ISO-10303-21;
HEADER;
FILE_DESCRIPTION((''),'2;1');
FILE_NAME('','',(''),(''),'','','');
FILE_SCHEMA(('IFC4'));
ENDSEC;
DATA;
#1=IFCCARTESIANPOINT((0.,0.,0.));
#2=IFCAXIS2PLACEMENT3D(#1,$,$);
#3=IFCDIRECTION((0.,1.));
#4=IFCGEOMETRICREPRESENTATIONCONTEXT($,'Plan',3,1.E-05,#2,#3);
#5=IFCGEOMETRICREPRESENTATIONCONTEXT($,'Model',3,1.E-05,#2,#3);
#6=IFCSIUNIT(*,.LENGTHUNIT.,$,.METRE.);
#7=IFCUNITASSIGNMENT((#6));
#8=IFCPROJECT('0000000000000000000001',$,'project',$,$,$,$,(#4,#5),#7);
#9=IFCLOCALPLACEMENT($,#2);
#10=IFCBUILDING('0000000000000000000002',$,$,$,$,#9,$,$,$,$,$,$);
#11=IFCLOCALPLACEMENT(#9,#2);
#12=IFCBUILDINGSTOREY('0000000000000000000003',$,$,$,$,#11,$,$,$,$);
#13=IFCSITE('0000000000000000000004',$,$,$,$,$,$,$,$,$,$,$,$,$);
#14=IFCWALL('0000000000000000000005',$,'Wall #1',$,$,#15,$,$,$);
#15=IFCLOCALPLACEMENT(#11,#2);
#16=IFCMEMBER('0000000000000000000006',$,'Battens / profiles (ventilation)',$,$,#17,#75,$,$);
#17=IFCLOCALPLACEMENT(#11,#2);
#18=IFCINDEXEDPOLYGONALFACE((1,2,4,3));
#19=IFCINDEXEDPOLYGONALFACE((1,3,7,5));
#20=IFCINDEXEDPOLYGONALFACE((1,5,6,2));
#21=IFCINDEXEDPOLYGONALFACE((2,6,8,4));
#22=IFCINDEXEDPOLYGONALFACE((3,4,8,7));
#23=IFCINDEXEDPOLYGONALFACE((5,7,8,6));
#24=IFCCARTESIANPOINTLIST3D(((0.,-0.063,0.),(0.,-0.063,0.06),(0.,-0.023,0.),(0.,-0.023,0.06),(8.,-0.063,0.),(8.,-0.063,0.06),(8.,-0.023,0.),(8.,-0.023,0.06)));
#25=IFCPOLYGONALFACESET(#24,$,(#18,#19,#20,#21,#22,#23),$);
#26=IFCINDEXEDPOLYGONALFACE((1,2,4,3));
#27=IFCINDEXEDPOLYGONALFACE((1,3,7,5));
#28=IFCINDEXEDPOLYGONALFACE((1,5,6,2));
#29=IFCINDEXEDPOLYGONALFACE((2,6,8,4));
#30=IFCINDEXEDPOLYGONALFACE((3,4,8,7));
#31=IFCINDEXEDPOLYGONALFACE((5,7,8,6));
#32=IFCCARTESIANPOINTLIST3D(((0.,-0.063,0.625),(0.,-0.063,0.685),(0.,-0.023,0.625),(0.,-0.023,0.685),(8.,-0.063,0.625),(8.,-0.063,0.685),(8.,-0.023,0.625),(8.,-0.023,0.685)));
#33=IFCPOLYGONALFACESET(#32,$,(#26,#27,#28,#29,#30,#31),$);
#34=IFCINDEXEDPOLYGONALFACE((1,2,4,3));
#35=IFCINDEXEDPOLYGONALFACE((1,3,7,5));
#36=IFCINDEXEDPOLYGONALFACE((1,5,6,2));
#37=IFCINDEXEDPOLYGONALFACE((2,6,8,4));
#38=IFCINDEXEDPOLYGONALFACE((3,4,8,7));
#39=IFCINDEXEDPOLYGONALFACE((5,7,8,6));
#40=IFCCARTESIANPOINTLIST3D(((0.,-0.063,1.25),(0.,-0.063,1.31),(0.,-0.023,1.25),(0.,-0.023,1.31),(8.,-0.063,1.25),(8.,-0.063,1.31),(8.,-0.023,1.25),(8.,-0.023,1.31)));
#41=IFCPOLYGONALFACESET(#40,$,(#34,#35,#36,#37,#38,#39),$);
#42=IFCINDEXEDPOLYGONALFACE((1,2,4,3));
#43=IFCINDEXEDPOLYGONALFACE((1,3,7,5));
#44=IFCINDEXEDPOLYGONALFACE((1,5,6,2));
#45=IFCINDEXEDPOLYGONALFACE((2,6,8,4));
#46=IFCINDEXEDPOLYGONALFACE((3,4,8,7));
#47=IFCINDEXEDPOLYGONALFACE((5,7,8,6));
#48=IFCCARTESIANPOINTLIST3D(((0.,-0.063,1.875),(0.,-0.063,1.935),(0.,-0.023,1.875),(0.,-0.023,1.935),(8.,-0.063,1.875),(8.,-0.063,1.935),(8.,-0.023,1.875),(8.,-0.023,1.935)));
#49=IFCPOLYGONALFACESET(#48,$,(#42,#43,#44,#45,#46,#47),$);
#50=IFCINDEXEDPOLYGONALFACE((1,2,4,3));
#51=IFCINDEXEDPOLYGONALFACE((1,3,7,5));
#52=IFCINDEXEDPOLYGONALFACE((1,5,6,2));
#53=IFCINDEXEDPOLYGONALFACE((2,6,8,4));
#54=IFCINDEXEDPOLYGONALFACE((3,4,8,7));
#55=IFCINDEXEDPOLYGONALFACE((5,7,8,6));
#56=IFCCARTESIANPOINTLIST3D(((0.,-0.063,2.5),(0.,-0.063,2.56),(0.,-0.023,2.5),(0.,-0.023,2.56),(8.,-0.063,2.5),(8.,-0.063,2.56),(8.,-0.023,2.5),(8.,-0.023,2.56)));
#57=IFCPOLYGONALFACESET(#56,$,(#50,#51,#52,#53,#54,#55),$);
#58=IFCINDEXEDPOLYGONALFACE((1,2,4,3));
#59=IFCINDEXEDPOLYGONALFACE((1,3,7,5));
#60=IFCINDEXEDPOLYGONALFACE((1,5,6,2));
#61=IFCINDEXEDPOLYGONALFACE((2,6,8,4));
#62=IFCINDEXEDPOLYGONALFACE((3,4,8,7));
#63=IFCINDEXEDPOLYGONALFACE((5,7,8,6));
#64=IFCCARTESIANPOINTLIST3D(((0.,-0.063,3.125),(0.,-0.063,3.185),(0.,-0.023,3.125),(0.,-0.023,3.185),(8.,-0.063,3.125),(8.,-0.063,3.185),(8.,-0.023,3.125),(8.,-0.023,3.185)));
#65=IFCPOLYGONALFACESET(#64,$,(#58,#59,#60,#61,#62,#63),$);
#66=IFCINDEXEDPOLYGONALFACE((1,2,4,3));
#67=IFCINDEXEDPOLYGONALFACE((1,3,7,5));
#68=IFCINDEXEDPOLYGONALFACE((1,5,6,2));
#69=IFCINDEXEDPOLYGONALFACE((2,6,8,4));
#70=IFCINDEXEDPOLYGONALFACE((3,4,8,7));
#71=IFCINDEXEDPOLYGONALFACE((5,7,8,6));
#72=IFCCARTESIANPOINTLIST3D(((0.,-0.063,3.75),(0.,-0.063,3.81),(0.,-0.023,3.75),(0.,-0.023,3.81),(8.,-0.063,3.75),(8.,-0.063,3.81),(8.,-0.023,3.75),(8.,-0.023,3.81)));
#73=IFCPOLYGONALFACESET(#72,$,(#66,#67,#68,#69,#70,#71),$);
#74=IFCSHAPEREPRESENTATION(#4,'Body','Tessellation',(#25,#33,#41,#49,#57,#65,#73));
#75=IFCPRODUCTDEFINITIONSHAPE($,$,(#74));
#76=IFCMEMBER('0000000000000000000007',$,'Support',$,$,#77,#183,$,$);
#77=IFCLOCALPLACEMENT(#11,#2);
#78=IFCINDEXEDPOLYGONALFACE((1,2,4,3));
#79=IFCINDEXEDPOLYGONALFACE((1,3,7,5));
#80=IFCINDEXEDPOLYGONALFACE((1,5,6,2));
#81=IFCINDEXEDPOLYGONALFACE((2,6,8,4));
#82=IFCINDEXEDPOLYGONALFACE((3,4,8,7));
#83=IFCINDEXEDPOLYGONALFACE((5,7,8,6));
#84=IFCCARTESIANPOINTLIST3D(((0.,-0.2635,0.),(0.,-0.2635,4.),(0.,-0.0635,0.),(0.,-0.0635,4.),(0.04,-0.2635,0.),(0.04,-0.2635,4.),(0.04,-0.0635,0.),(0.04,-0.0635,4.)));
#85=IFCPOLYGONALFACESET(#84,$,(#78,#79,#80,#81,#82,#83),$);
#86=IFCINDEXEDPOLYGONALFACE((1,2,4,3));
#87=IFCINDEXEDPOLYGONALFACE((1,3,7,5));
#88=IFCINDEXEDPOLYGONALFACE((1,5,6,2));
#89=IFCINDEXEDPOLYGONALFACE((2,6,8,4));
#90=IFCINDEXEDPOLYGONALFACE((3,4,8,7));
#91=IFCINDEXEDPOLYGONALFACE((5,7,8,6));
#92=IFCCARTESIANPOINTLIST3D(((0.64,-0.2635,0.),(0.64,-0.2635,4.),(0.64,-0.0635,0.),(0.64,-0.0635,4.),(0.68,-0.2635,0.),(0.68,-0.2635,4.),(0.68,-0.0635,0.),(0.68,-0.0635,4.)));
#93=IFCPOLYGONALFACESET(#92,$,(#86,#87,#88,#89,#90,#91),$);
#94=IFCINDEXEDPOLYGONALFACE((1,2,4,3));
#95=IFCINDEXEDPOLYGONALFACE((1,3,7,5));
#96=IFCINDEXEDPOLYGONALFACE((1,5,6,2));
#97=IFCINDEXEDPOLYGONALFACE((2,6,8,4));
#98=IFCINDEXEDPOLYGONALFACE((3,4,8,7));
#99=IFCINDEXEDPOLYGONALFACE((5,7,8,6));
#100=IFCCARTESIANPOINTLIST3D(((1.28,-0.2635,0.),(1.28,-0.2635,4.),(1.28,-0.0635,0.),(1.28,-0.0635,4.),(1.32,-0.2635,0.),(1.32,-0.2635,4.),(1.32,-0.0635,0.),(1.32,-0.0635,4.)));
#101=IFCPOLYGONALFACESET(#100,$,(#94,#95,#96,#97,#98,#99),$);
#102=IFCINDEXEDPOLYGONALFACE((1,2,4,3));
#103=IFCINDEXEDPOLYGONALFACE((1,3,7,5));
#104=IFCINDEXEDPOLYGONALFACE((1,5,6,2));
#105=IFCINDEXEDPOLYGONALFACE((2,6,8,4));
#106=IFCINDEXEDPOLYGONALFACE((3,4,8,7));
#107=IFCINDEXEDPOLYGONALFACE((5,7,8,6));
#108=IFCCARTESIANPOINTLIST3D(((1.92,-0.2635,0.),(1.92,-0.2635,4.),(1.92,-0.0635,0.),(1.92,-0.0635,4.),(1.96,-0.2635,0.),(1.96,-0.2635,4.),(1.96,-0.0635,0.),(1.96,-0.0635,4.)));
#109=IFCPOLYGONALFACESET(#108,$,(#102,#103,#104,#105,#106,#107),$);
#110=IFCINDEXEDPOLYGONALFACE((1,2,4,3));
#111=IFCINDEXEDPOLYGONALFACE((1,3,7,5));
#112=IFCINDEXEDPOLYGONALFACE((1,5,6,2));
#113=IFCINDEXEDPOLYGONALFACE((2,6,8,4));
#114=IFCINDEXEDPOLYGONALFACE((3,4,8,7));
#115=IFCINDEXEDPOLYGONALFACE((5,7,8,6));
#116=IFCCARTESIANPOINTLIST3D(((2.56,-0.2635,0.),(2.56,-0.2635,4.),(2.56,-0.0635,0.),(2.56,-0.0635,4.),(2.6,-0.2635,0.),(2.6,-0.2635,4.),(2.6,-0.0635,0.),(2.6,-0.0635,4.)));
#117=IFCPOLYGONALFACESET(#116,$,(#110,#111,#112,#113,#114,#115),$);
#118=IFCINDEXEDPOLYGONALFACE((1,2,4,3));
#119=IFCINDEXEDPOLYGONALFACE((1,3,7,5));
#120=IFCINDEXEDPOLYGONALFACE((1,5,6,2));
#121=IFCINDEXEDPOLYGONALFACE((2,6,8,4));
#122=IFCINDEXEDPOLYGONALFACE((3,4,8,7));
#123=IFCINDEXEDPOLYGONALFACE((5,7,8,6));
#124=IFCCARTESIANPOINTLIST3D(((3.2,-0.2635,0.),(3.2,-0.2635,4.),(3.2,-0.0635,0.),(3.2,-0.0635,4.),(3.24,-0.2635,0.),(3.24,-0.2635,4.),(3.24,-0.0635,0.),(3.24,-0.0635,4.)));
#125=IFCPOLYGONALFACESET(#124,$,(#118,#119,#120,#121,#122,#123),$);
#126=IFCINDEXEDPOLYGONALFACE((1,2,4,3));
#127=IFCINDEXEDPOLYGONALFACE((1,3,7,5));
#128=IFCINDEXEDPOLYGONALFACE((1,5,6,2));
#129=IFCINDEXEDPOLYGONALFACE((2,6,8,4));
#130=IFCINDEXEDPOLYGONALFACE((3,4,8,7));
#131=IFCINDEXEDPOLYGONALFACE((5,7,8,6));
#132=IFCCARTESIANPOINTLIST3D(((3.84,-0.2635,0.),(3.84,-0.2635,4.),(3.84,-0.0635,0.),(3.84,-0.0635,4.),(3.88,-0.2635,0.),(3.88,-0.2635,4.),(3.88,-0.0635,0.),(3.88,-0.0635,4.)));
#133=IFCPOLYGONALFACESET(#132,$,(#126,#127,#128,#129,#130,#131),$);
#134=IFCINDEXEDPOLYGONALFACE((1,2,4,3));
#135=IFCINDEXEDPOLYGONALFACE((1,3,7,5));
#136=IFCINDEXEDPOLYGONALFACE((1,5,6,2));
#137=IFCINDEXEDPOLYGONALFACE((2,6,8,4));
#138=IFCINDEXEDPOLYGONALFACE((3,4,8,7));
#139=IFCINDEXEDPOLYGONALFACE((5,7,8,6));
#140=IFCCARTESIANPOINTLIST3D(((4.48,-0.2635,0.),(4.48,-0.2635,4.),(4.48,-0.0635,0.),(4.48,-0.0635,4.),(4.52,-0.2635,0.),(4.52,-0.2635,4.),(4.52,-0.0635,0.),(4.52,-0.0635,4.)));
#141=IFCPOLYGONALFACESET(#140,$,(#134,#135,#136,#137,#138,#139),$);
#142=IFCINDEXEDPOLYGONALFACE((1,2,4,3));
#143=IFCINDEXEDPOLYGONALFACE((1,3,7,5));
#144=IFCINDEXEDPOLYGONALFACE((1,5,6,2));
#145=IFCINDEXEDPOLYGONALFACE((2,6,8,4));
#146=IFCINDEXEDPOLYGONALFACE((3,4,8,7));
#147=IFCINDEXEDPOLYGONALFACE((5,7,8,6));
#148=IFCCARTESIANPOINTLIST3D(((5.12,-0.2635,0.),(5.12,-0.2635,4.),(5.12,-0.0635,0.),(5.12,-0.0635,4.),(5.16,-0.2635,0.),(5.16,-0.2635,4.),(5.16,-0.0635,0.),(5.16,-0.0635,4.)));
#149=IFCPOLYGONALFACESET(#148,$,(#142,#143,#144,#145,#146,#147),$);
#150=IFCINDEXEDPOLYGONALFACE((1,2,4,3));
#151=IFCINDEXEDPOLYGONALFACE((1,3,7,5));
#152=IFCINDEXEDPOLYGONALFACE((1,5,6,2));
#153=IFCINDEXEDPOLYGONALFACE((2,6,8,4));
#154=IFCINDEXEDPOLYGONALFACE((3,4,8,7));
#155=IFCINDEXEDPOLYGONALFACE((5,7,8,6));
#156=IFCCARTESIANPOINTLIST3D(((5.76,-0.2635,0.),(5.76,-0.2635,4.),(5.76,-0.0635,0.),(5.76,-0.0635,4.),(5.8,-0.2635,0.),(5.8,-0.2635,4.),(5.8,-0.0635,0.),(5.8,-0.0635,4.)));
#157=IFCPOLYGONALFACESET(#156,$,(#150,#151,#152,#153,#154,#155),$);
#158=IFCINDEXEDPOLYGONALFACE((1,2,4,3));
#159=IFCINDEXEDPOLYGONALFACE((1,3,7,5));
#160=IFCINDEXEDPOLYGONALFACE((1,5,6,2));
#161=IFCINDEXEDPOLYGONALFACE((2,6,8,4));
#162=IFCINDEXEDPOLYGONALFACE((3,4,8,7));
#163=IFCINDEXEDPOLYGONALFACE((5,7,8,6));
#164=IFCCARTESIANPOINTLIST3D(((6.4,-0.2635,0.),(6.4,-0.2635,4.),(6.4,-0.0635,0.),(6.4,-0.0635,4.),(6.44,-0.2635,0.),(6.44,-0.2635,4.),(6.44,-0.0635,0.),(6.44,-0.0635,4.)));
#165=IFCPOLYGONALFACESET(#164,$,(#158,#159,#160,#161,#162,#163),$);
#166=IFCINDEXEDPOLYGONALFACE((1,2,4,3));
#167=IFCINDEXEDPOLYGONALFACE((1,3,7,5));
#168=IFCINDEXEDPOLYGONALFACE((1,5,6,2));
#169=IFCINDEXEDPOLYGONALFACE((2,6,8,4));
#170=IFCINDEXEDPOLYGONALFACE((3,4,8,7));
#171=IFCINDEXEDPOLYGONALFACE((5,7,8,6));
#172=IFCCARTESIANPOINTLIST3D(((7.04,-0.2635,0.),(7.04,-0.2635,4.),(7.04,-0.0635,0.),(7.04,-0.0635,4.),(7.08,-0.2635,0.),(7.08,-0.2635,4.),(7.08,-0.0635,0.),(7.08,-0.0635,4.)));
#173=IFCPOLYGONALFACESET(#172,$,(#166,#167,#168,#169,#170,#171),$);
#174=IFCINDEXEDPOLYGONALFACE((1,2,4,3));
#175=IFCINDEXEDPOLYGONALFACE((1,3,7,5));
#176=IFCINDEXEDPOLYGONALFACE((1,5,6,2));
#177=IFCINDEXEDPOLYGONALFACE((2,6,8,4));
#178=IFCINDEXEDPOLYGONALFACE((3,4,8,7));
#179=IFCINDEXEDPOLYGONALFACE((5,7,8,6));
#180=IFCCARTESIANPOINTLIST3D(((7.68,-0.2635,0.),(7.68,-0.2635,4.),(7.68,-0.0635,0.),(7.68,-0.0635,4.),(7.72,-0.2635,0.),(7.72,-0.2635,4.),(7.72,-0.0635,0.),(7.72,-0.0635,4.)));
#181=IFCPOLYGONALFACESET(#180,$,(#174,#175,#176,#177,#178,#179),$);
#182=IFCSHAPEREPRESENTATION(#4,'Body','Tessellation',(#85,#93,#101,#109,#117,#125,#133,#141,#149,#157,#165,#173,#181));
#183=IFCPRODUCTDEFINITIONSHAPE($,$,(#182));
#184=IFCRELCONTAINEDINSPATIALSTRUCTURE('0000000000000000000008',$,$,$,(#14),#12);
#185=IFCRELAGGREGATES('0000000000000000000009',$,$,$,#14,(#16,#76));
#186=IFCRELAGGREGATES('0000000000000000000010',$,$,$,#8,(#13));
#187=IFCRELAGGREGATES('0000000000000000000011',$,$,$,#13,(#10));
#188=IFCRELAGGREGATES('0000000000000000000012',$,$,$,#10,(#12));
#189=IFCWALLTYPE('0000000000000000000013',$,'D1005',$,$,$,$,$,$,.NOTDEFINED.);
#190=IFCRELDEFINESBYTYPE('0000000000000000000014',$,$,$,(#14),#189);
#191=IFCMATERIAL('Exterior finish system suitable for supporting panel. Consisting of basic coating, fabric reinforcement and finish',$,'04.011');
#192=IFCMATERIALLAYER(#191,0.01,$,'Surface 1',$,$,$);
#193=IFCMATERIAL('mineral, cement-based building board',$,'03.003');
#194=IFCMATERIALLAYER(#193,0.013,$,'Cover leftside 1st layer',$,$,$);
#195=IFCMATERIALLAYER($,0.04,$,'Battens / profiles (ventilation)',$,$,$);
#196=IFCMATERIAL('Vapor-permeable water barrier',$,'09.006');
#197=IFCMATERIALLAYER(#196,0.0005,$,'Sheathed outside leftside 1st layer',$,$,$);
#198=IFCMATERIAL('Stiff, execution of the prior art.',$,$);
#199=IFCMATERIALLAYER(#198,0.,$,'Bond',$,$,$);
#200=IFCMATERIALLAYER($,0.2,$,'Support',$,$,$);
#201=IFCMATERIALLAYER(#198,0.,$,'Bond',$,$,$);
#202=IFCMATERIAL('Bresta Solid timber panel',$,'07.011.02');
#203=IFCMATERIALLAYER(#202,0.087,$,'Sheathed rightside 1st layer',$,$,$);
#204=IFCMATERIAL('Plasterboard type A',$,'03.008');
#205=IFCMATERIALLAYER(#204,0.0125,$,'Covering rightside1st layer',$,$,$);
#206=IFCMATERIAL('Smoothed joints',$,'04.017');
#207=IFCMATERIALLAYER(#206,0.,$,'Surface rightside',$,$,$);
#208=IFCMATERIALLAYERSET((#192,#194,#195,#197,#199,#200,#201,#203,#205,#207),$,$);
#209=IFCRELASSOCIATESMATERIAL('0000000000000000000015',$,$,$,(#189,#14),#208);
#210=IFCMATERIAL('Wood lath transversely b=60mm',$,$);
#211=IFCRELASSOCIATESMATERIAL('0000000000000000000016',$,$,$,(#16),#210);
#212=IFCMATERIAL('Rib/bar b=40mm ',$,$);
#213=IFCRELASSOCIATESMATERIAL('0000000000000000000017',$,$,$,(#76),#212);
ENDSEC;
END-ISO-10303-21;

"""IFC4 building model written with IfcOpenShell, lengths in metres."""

from ifc_helpers import new_model, si_unit, direction, frame, frame_2d, origin, place, context, project, spatial, rectangle, extrude, material, layer, layer_set, type_object, element, aggregate, save


model = new_model("IFC4")

# Units and contexts
plan_context = context("Plan", 3, precision=1e-05, world=origin(), true_north=direction((0.0, 1.0)))
model_context = context("Model", 3, precision=1e-05, world=origin(), true_north=direction((0.0, 1.0)))
ifc_project = project(units=[si_unit("LENGTHUNIT", "METRE")], contexts=[plan_context, model_context])

# Site, building, storey
site = spatial("IfcSite", under=ifc_project)
building_placement = place(None, origin())
building = spatial("IfcBuilding", under=site, at=building_placement)
storey_placement = place(building_placement, origin())
storey = spatial("IfcBuildingStorey", under=building, at=storey_placement)

# Wall, members
ifc_material_1 = material(Name="Exterior finish system suitable for supporting panel. Consisting of basic coating, fabric reinforcement and finish", Category="04.011")
ifc_layer_1 = layer(ifc_material_1, 0.01, Name="Surface 1")
ifc_material_2 = material(Name="mineral, cement-based building board", Category="03.003")
ifc_layer_2 = layer(ifc_material_2, 0.013, Name="Cover leftside 1st layer")
ifc_layer_3 = layer(None, 0.04, Name="Battens / profiles (ventilation)")
ifc_material_3 = material(Name="Vapor-permeable water barrier", Category="09.006")
ifc_layer_4 = layer(ifc_material_3, 0.0005, Name="Sheathed outside leftside 1st layer")
ifc_material_4 = material(Name="Stiff, execution of the prior art.")
ifc_layer_5 = layer(ifc_material_4, 0.0, Name="Bond")
ifc_layer_6 = layer(None, 0.2, Name="Support")
ifc_layer_7 = layer(ifc_material_4, 0.0, Name="Bond")
ifc_material_5 = material(Name="Bresta Solid timber panel", Category="07.011.02")
ifc_layer_8 = layer(ifc_material_5, 0.087, Name="Sheathed rightside 1st layer")
ifc_material_6 = material(Name="Plasterboard type A", Category="03.008")
ifc_layer_9 = layer(ifc_material_6, 0.0125, Name="Covering rightside1st layer")
ifc_material_7 = material(Name="Smoothed joints", Category="04.017")
ifc_layer_10 = layer(ifc_material_7, 0.0, Name="Surface rightside")
ifc_layer_set = layer_set([ifc_layer_1, ifc_layer_2, ifc_layer_3, ifc_layer_4, ifc_layer_5, ifc_layer_6, ifc_layer_7, ifc_layer_8, ifc_layer_9, ifc_layer_10])
wall_type = type_object("IfcWallType", Name="D1005", PredefinedType="NOTDEFINED", material=ifc_layer_set)
wall_placement = place(None, frame((0.0, 0.0, 0.0), z_axis=(0.0, -1.0, 0.0), x_axis=(1.0, 0.0, 0.0)))
wall = element("IfcWall", 1, at=wall_placement, inside=storey, type_object=wall_type, material=ifc_layer_set, Name="Wall #1")
ifc_material_8 = material(Name="Wood lath transversely b=60mm")
member_1_placement = place(wall_placement, origin())
member_1 = element("IfcMember", 2, at=member_1_placement, material=ifc_material_8, Name="Battens / profiles (ventilation)", context=plan_context, shape_type="SweptSolid", body=[
    extrude(rectangle(XDim=0.06, YDim=0.04, at=frame_2d((0.03, 0.02), x_axis=(1.0, 0.0))), frame((0.0, 0.0, 0.023), z_axis=(1.0, 0.0, 0.0), x_axis=(0.0, 1.0, 0.0)), (0.0, 0.0, 1.0), 8.0),
    extrude(rectangle(XDim=0.06, YDim=0.04, at=frame_2d((0.03, 0.02), x_axis=(1.0, 0.0))), frame((0.0, 0.625, 0.023), z_axis=(1.0, 0.0, 0.0), x_axis=(0.0, 1.0, 0.0)), (0.0, 0.0, 1.0), 8.0),
    extrude(rectangle(XDim=0.06, YDim=0.04, at=frame_2d((0.03, 0.02), x_axis=(1.0, 0.0))), frame((0.0, 1.25, 0.023), z_axis=(1.0, 0.0, 0.0), x_axis=(0.0, 1.0, 0.0)), (0.0, 0.0, 1.0), 8.0),
    extrude(rectangle(XDim=0.06, YDim=0.04, at=frame_2d((0.03, 0.02), x_axis=(1.0, 0.0))), frame((0.0, 1.875, 0.023), z_axis=(1.0, 0.0, 0.0), x_axis=(0.0, 1.0, 0.0)), (0.0, 0.0, 1.0), 8.0),
    extrude(rectangle(XDim=0.06, YDim=0.04, at=frame_2d((0.03, 0.02), x_axis=(1.0, 0.0))), frame((0.0, 2.5, 0.023), z_axis=(1.0, 0.0, 0.0), x_axis=(0.0, 1.0, 0.0)), (0.0, 0.0, 1.0), 8.0),
    extrude(rectangle(XDim=0.06, YDim=0.04, at=frame_2d((0.03, 0.02), x_axis=(1.0, 0.0))), frame((0.0, 3.125, 0.023), z_axis=(1.0, 0.0, 0.0), x_axis=(0.0, 1.0, 0.0)), (0.0, 0.0, 1.0), 8.0),
    extrude(rectangle(XDim=0.06, YDim=0.04, at=frame_2d((0.03, 0.02), x_axis=(1.0, 0.0))), frame((0.0, 3.75, 0.023), z_axis=(1.0, 0.0, 0.0), x_axis=(0.0, 1.0, 0.0)), (0.0, 0.0, 1.0), 8.0),
])
ifc_material_9 = material(Name="Rib/bar b=40mm ")
member_2_placement = place(wall_placement, origin())
member_2 = element("IfcMember", 3, at=member_2_placement, material=ifc_material_9, Name="Support", context=plan_context, shape_type="SweptSolid", body=[
    extrude(rectangle(XDim=0.04, YDim=0.2, at=frame_2d((0.02, 0.1), x_axis=(1.0, 0.0))), frame((0.0, 4.0, 0.0635), z_axis=(0.0, -1.0, 0.0), x_axis=(1.0, 0.0, 0.0)), (0.0, 0.0, 1.0), 4.0),
    extrude(rectangle(XDim=0.04, YDim=0.2, at=frame_2d((0.02, 0.1), x_axis=(1.0, 0.0))), frame((0.64, 4.0, 0.0635), z_axis=(0.0, -1.0, 0.0), x_axis=(1.0, 0.0, 0.0)), (0.0, 0.0, 1.0), 4.0),
    extrude(rectangle(XDim=0.04, YDim=0.2, at=frame_2d((0.02, 0.1), x_axis=(1.0, 0.0))), frame((1.28, 4.0, 0.0635), z_axis=(0.0, -1.0, 0.0), x_axis=(1.0, 0.0, 0.0)), (0.0, 0.0, 1.0), 4.0),
    extrude(rectangle(XDim=0.04, YDim=0.2, at=frame_2d((0.02, 0.1), x_axis=(1.0, 0.0))), frame((1.92, 4.0, 0.0635), z_axis=(0.0, -1.0, 0.0), x_axis=(1.0, 0.0, 0.0)), (0.0, 0.0, 1.0), 4.0),
    extrude(rectangle(XDim=0.04, YDim=0.2, at=frame_2d((0.02, 0.1), x_axis=(1.0, 0.0))), frame((2.56, 4.0, 0.0635), z_axis=(0.0, -1.0, 0.0), x_axis=(1.0, 0.0, 0.0)), (0.0, 0.0, 1.0), 4.0),
    extrude(rectangle(XDim=0.04, YDim=0.2, at=frame_2d((0.02, 0.1), x_axis=(1.0, 0.0))), frame((3.2, 4.0, 0.0635), z_axis=(0.0, -1.0, 0.0), x_axis=(1.0, 0.0, 0.0)), (0.0, 0.0, 1.0), 4.0),
    extrude(rectangle(XDim=0.04, YDim=0.2, at=frame_2d((0.02, 0.1), x_axis=(1.0, 0.0))), frame((3.84, 4.0, 0.0635), z_axis=(0.0, -1.0, 0.0), x_axis=(1.0, 0.0, 0.0)), (0.0, 0.0, 1.0), 4.0),
    extrude(rectangle(XDim=0.04, YDim=0.2, at=frame_2d((0.02, 0.1), x_axis=(1.0, 0.0))), frame((4.48, 4.0, 0.0635), z_axis=(0.0, -1.0, 0.0), x_axis=(1.0, 0.0, 0.0)), (0.0, 0.0, 1.0), 4.0),
    extrude(rectangle(XDim=0.04, YDim=0.2, at=frame_2d((0.02, 0.1), x_axis=(1.0, 0.0))), frame((5.12, 4.0, 0.0635), z_axis=(0.0, -1.0, 0.0), x_axis=(1.0, 0.0, 0.0)), (0.0, 0.0, 1.0), 4.0),
    extrude(rectangle(XDim=0.04, YDim=0.2, at=frame_2d((0.02, 0.1), x_axis=(1.0, 0.0))), frame((5.76, 4.0, 0.0635), z_axis=(0.0, -1.0, 0.0), x_axis=(1.0, 0.0, 0.0)), (0.0, 0.0, 1.0), 4.0),
    extrude(rectangle(XDim=0.04, YDim=0.2, at=frame_2d((0.02, 0.1), x_axis=(1.0, 0.0))), frame((6.4, 4.0, 0.0635), z_axis=(0.0, -1.0, 0.0), x_axis=(1.0, 0.0, 0.0)), (0.0, 0.0, 1.0), 4.0),
    extrude(rectangle(XDim=0.04, YDim=0.2, at=frame_2d((0.02, 0.1), x_axis=(1.0, 0.0))), frame((7.04, 4.0, 0.0635), z_axis=(0.0, -1.0, 0.0), x_axis=(1.0, 0.0, 0.0)), (0.0, 0.0, 1.0), 4.0),
    extrude(rectangle(XDim=0.04, YDim=0.2, at=frame_2d((0.02, 0.1), x_axis=(1.0, 0.0))), frame((7.68, 4.0, 0.0635), z_axis=(0.0, -1.0, 0.0), x_axis=(1.0, 0.0, 0.0)), (0.0, 0.0, 1.0), 4.0),
])
aggregate(wall, [member_1, member_2])

save(model, "model.ifc")
